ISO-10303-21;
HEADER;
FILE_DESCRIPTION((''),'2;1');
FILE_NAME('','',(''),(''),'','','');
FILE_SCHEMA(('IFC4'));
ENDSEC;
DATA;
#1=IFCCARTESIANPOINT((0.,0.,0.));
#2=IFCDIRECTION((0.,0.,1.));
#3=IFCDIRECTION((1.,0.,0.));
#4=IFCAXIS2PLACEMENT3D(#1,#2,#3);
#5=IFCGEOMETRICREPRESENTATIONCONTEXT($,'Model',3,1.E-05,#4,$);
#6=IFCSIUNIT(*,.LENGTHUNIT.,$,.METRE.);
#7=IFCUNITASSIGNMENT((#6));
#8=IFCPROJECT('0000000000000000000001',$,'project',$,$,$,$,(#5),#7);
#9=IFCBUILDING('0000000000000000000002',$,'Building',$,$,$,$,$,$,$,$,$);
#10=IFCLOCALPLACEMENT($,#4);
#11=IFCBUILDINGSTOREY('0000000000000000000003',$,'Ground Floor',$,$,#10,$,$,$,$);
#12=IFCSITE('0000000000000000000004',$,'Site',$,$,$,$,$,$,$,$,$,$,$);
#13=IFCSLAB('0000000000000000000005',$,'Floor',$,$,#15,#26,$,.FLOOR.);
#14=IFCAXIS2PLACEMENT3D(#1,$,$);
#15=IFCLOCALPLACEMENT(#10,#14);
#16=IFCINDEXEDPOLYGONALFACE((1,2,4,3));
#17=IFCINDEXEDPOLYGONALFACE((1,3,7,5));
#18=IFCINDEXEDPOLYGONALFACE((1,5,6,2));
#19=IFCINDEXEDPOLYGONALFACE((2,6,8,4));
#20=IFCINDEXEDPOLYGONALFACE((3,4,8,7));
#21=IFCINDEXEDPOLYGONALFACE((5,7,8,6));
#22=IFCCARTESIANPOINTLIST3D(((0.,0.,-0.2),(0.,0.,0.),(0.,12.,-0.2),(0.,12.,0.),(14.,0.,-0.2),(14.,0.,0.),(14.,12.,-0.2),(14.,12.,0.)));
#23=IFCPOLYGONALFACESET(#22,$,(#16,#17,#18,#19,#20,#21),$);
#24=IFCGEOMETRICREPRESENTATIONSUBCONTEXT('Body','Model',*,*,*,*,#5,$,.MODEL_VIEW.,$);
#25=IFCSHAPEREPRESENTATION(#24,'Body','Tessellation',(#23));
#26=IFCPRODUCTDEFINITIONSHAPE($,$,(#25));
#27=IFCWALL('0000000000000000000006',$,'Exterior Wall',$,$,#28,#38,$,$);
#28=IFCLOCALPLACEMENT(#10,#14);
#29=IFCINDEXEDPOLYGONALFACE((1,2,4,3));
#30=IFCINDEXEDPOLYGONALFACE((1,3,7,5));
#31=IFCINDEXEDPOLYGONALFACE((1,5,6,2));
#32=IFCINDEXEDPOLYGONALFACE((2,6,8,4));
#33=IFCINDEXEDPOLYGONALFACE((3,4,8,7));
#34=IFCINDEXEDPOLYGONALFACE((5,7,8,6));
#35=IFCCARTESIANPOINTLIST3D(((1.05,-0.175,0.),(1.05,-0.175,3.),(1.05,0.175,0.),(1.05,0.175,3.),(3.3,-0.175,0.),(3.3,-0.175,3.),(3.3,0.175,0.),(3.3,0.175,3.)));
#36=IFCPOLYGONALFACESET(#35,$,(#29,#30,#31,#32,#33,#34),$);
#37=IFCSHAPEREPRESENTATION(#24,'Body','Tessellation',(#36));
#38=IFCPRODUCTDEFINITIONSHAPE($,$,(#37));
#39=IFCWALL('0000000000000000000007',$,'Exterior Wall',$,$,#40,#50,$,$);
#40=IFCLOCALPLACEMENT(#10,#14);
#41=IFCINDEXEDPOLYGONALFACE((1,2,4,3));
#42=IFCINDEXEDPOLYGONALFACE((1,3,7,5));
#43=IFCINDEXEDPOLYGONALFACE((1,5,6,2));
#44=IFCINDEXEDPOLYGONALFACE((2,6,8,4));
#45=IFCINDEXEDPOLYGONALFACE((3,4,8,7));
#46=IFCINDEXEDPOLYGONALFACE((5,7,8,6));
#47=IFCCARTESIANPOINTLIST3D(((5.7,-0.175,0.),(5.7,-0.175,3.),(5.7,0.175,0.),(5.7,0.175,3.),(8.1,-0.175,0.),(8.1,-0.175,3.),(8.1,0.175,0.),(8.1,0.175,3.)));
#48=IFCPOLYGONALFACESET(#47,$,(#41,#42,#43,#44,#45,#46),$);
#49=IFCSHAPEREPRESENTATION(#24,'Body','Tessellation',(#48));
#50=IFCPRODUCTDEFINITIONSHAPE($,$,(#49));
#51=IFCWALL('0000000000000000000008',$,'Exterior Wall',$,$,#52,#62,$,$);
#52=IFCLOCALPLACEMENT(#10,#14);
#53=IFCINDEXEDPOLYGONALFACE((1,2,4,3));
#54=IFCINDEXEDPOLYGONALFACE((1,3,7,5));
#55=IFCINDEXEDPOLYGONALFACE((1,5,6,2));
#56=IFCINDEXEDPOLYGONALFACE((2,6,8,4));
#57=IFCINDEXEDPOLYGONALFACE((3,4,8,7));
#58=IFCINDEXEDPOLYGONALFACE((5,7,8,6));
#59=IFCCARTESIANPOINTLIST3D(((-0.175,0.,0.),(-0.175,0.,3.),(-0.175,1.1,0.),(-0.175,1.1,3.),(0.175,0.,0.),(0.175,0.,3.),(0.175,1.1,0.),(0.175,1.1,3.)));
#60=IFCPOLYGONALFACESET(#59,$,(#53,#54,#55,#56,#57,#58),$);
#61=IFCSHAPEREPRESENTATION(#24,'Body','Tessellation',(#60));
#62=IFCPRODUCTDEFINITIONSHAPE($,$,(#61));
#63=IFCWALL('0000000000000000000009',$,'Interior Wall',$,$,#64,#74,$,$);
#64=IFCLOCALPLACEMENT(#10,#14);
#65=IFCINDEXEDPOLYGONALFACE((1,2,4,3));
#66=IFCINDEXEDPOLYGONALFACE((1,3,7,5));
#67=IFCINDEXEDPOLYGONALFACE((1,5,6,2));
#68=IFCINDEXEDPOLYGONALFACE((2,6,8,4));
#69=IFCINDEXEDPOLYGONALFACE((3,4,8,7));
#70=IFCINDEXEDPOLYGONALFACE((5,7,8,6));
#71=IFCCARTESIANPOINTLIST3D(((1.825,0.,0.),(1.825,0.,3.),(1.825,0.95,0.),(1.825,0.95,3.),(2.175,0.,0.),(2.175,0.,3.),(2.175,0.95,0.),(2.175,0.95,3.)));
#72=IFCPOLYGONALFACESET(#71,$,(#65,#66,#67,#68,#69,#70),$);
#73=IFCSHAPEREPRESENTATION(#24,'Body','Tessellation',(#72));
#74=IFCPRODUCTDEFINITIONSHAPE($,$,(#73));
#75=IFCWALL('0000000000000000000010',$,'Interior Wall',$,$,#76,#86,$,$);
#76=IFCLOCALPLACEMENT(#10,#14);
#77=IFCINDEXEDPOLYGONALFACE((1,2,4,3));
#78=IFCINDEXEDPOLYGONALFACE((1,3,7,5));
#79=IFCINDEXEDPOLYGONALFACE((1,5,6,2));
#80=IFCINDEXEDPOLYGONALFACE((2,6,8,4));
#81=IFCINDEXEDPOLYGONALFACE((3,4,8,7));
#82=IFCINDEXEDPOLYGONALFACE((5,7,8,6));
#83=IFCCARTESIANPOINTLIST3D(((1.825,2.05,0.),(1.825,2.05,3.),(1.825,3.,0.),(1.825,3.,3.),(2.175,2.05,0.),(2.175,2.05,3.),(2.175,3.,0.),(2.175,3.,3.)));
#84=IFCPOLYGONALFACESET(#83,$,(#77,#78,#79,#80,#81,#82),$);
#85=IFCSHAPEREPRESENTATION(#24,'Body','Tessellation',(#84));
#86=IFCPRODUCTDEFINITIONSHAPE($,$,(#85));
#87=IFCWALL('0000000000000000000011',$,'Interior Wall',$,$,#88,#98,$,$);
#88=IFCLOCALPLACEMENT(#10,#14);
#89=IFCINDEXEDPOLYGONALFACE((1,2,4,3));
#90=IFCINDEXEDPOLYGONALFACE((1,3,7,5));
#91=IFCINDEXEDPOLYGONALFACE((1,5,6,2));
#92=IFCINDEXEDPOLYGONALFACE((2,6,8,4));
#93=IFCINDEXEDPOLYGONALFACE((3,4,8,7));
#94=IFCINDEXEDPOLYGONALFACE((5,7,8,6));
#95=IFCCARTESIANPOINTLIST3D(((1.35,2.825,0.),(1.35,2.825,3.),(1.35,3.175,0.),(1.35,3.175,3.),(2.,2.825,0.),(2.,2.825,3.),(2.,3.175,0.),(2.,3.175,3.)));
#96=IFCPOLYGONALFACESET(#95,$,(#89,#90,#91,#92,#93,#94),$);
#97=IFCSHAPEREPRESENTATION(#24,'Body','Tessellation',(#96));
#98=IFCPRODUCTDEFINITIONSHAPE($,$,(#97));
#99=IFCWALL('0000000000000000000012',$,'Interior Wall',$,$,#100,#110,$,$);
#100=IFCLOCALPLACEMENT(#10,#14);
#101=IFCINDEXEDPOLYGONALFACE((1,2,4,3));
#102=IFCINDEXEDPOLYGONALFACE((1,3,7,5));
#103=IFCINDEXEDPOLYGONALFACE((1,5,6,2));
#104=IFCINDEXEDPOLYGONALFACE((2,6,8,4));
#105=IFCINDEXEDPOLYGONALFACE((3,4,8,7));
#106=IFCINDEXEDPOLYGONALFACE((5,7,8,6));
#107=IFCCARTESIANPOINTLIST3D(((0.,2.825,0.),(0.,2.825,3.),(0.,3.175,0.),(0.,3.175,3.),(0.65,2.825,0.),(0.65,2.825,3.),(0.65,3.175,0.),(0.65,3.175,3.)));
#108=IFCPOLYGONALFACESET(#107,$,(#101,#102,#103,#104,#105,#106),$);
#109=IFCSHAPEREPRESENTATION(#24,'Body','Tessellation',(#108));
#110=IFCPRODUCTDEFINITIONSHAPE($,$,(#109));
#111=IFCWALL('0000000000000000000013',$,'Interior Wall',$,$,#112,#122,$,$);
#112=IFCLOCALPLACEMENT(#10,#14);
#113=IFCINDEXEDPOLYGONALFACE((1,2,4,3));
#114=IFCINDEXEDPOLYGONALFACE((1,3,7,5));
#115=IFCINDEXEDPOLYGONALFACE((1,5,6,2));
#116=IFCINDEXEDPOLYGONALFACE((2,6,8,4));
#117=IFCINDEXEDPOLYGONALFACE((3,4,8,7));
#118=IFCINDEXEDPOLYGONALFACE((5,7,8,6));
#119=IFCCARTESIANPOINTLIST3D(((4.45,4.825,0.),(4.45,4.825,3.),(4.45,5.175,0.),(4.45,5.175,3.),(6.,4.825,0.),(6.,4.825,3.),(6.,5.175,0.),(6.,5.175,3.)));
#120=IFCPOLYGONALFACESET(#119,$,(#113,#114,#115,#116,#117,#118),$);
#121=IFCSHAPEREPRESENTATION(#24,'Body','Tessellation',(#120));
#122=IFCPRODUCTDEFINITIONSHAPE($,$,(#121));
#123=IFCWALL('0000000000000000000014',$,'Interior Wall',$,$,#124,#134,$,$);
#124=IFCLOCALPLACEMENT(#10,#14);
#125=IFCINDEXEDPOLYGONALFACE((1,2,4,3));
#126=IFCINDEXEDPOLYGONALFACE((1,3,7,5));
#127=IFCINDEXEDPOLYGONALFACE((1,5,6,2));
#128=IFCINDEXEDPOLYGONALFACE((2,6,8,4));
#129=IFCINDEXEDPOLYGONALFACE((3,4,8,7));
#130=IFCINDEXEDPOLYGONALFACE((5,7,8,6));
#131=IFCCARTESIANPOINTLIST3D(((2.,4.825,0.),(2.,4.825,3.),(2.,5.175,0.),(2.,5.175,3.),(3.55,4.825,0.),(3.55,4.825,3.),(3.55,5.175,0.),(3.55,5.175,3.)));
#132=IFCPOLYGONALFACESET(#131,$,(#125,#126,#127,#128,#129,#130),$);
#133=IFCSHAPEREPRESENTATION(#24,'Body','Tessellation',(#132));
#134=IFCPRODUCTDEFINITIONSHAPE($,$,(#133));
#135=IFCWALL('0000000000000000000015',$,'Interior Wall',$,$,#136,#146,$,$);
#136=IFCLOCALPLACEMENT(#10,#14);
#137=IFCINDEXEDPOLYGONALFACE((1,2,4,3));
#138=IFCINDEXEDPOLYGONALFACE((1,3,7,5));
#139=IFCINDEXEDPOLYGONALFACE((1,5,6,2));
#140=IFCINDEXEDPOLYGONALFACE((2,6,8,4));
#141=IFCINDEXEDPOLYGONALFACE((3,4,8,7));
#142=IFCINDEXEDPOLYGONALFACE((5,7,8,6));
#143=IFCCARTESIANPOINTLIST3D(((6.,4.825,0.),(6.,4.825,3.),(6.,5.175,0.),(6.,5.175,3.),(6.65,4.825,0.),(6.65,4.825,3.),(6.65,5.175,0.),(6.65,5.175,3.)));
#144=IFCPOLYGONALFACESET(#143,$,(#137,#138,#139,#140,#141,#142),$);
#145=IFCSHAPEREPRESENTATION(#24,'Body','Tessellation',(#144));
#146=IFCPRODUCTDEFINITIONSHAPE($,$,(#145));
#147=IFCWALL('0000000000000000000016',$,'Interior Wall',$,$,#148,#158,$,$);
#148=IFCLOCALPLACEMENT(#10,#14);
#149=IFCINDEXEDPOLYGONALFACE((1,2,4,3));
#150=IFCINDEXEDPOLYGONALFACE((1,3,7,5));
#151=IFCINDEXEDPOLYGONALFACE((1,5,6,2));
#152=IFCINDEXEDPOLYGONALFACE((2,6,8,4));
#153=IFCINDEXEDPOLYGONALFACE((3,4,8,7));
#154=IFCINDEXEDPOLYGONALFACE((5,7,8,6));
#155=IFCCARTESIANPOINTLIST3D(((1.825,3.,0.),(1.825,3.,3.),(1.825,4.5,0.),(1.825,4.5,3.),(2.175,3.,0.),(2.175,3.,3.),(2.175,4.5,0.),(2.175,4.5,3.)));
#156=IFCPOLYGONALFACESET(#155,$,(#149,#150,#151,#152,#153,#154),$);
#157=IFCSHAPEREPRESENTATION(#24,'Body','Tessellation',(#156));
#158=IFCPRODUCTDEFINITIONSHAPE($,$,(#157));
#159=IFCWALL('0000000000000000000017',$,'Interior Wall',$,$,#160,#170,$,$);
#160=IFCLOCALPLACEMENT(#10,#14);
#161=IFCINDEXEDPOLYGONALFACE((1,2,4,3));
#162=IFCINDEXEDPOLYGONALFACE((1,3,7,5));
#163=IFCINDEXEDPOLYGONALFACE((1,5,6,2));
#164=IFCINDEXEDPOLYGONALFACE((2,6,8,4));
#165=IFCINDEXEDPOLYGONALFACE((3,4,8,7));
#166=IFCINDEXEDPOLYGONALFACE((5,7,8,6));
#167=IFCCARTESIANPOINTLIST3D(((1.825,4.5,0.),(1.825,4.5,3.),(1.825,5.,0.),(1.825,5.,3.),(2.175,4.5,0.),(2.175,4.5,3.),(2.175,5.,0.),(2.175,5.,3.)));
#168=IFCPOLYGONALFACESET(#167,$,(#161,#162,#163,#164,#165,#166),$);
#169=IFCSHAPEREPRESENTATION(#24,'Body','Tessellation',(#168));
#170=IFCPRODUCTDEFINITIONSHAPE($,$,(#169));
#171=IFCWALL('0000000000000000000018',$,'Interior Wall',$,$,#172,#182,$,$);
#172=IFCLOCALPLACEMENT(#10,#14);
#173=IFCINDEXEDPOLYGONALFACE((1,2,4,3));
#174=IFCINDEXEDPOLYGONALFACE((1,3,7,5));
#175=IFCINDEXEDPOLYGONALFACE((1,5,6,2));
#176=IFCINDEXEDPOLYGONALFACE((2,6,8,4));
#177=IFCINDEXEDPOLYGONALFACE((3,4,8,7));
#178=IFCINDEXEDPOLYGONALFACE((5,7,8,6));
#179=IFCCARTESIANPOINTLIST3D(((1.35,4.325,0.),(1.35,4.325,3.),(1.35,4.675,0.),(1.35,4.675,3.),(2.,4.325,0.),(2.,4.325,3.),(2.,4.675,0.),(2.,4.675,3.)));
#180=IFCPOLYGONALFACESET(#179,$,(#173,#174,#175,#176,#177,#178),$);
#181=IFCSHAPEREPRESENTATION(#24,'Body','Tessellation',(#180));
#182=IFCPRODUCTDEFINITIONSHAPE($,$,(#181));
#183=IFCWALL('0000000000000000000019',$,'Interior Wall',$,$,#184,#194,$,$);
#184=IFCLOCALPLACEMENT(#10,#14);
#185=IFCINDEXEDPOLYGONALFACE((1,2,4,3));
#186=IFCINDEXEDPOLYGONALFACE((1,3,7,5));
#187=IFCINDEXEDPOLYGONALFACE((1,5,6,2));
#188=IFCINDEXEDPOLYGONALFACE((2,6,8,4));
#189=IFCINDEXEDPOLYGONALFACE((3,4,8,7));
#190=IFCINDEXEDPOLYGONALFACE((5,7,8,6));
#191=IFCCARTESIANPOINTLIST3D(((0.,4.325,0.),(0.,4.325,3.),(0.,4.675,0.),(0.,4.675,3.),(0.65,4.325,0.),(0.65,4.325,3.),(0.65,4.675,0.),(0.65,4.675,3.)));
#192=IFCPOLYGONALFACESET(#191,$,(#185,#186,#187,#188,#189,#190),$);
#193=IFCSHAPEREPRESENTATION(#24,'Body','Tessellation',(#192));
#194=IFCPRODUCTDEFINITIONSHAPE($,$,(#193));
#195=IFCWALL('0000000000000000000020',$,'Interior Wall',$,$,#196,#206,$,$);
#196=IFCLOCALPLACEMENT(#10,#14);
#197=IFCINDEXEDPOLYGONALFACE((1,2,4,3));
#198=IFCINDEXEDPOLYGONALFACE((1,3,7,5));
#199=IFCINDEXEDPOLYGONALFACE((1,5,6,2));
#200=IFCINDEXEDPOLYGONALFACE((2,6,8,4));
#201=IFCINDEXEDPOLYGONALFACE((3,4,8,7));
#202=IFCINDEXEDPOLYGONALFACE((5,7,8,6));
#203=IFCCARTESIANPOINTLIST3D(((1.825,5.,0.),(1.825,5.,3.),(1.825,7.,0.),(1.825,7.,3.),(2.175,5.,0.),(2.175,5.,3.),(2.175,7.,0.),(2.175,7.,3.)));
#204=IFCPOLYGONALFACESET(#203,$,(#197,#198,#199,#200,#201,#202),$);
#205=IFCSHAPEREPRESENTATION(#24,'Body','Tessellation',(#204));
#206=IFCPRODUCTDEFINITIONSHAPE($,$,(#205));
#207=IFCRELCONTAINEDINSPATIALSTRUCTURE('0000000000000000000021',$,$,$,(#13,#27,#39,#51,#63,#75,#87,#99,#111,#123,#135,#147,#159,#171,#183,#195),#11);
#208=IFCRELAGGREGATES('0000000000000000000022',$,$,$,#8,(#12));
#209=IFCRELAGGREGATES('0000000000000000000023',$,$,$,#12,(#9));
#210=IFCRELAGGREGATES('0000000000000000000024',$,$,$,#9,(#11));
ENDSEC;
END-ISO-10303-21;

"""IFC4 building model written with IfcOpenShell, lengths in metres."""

from ifc_helpers import new_model, si_unit, frame, origin_with_axes, place, context, subcontext, project, spatial, indexed_curve, outline, extrude, element, save


model = new_model("IFC4")

# Units and contexts
model_context = context("Model", 3, precision=1e-05, world=origin_with_axes())
body_context = subcontext(model_context, "Body", "Model", "MODEL_VIEW")
ifc_project = project(units=[si_unit("LENGTHUNIT", "METRE")], contexts=[model_context])

# Site, building, storey
site = spatial("IfcSite", under=ifc_project, Name="Site")
building = spatial("IfcBuilding", under=site, Name="Building")
storey_placement = place(None, origin_with_axes())
storey = spatial("IfcBuildingStorey", under=building, at=storey_placement, Name="Ground Floor")

# Slab
slab_placement = place(storey_placement, frame((0.0, 0.0, -0.2), z_axis=(0.0, 0.0, 1.0), x_axis=(1.0, 0.0, 0.0)))
element("IfcSlab", 1, at=slab_placement, inside=storey, Name="Floor", PredefinedType="FLOOR", context=body_context, shape_type="SweptSolid", body=[
    extrude(outline(indexed_curve([(0.0, 0.0), (14.0, 0.0), (14.0, 12.0), (0.0, 12.0)])), None, (0.0, 0.0, 1.0), 0.2),
])

# Walls
wall_1_placement = place(storey_placement, frame((1.05, 0.0, 0.0), z_axis=(0.0, 0.0, 1.0), x_axis=(1.0, 0.0, 0.0)))
element("IfcWall", 2, at=wall_1_placement, inside=storey, Name="Exterior Wall", context=body_context, shape_type="SweptSolid", body=[
    extrude(outline(indexed_curve([(0.0, 0.0), (0.0, 0.35), (2.25, 0.35), (2.25, 0.0), (0.0, 0.0)], self_intersect=False)), frame((0.0, -0.175, 0.0), z_axis=(0.0, 0.0, 1.0), x_axis=(1.0, 0.0, 0.0)), (0.0, 0.0, 1.0), 3.0),
])
wall_2_placement = place(storey_placement, frame((5.7, 0.0, 0.0), z_axis=(0.0, 0.0, 1.0), x_axis=(1.0, 0.0, 0.0)))
element("IfcWall", 3, at=wall_2_placement, inside=storey, Name="Exterior Wall", context=body_context, shape_type="SweptSolid", body=[
    extrude(outline(indexed_curve([(0.0, 0.0), (0.0, 0.35), (2.4, 0.35), (2.4, 0.0), (0.0, 0.0)], self_intersect=False)), frame((0.0, -0.175, 0.0), z_axis=(0.0, 0.0, 1.0), x_axis=(1.0, 0.0, 0.0)), (0.0, 0.0, 1.0), 3.0),
])
wall_3_placement = place(storey_placement, frame((0.0, 1.1, 0.0), z_axis=(0.0, 0.0, 1.0), x_axis=(0.0, -1.0, 0.0)))
element("IfcWall", 4, at=wall_3_placement, inside=storey, Name="Exterior Wall", context=body_context, shape_type="SweptSolid", body=[
    extrude(outline(indexed_curve([(0.0, 0.0), (0.0, 0.35), (1.1, 0.35), (1.1, 0.0), (0.0, 0.0)], self_intersect=False)), frame((0.0, -0.175, 0.0), z_axis=(0.0, 0.0, 1.0), x_axis=(1.0, 0.0, 0.0)), (0.0, 0.0, 1.0), 3.0),
])
wall_4_placement = place(storey_placement, frame((2.0, 0.0, 0.0), z_axis=(0.0, 0.0, 1.0), x_axis=(0.0, 1.0, 0.0)))
element("IfcWall", 5, at=wall_4_placement, inside=storey, Name="Interior Wall", context=body_context, shape_type="SweptSolid", body=[
    extrude(outline(indexed_curve([(0.0, 0.0), (0.0, 0.35), (0.95, 0.35), (0.95, 0.0), (0.0, 0.0)], self_intersect=False)), frame((0.0, -0.175, 0.0), z_axis=(0.0, 0.0, 1.0), x_axis=(1.0, 0.0, 0.0)), (0.0, 0.0, 1.0), 3.0),
])
wall_5_placement = place(storey_placement, frame((2.0, 2.05, 0.0), z_axis=(0.0, 0.0, 1.0), x_axis=(0.0, 1.0, 0.0)))
element("IfcWall", 6, at=wall_5_placement, inside=storey, Name="Interior Wall", context=body_context, shape_type="SweptSolid", body=[
    extrude(outline(indexed_curve([(0.0, 0.0), (0.0, 0.35), (0.95, 0.35), (0.95, 0.0), (0.0, 0.0)], self_intersect=False)), frame((0.0, -0.175, 0.0), z_axis=(0.0, 0.0, 1.0), x_axis=(1.0, 0.0, 0.0)), (0.0, 0.0, 1.0), 3.0),
])
for number, where, z_axis, x_axis, name in (
    (7, (2.0, 3.0, 0.0), (0.0, 0.0, 1.0), (-1.0, 0.0, 0.0), "Interior Wall"),
    (8, (0.65, 3.0, 0.0), (0.0, 0.0, 1.0), (-1.0, 0.0, 0.0), "Interior Wall"),
):
    element("IfcWall", number, at=place(storey_placement, frame(where, z_axis=z_axis, x_axis=x_axis)), inside=storey, Name=name, context=body_context, shape_type="SweptSolid", body=[
        extrude(outline(indexed_curve([(0.0, 0.0), (0.0, 0.35), (0.65, 0.35), (0.65, 0.0), (0.0, 0.0)], self_intersect=False)), frame((0.0, -0.175, 0.0), z_axis=(0.0, 0.0, 1.0), x_axis=(1.0, 0.0, 0.0)), (0.0, 0.0, 1.0), 3.0),
    ])
for number, where, z_axis, x_axis, name in (
    (9, (6.0, 5.0, 0.0), (0.0, 0.0, 1.0), (-1.0, 0.0, 0.0), "Interior Wall"),
    (10, (3.55, 5.0, 0.0), (0.0, 0.0, 1.0), (-1.0, 0.0, 0.0), "Interior Wall"),
):
    element("IfcWall", number, at=place(storey_placement, frame(where, z_axis=z_axis, x_axis=x_axis)), inside=storey, Name=name, context=body_context, shape_type="SweptSolid", body=[
        extrude(outline(indexed_curve([(0.0, 0.0), (0.0, 0.35), (1.55, 0.35), (1.55, 0.0), (0.0, 0.0)], self_intersect=False)), frame((0.0, -0.175, 0.0), z_axis=(0.0, 0.0, 1.0), x_axis=(1.0, 0.0, 0.0)), (0.0, 0.0, 1.0), 3.0),
    ])
wall_6_placement = place(storey_placement, frame((6.65, 5.0, 0.0), z_axis=(0.0, 0.0, 1.0), x_axis=(-1.0, 0.0, 0.0)))
element("IfcWall", 11, at=wall_6_placement, inside=storey, Name="Interior Wall", context=body_context, shape_type="SweptSolid", body=[
    extrude(outline(indexed_curve([(0.0, 0.0), (0.0, 0.35), (0.65, 0.35), (0.65, 0.0), (0.0, 0.0)], self_intersect=False)), frame((0.0, -0.175, 0.0), z_axis=(0.0, 0.0, 1.0), x_axis=(1.0, 0.0, 0.0)), (0.0, 0.0, 1.0), 3.0),
])
wall_7_placement = place(storey_placement, frame((2.0, 4.5, 0.0), z_axis=(0.0, 0.0, 1.0), x_axis=(0.0, -1.0, 0.0)))
element("IfcWall", 12, at=wall_7_placement, inside=storey, Name="Interior Wall", context=body_context, shape_type="SweptSolid", body=[
    extrude(outline(indexed_curve([(0.0, 0.0), (0.0, 0.35), (1.5, 0.35), (1.5, 0.0), (0.0, 0.0)], self_intersect=False)), frame((0.0, -0.175, 0.0), z_axis=(0.0, 0.0, 1.0), x_axis=(1.0, 0.0, 0.0)), (0.0, 0.0, 1.0), 3.0),
])
wall_8_placement = place(storey_placement, frame((2.0, 5.0, 0.0), z_axis=(0.0, 0.0, 1.0), x_axis=(0.0, -1.0, 0.0)))
element("IfcWall", 13, at=wall_8_placement, inside=storey, Name="Interior Wall", context=body_context, shape_type="SweptSolid", body=[
    extrude(outline(indexed_curve([(0.0, 0.0), (0.0, 0.35), (0.5, 0.35), (0.5, 0.0), (0.0, 0.0)], self_intersect=False)), frame((0.0, -0.175, 0.0), z_axis=(0.0, 0.0, 1.0), x_axis=(1.0, 0.0, 0.0)), (0.0, 0.0, 1.0), 3.0),
])
for number, where, z_axis, x_axis, name in (
    (14, (2.0, 4.5, 0.0), (0.0, 0.0, 1.0), (-1.0, 0.0, 0.0), "Interior Wall"),
    (15, (0.65, 4.5, 0.0), (0.0, 0.0, 1.0), (-1.0, 0.0, 0.0), "Interior Wall"),
):
    element("IfcWall", number, at=place(storey_placement, frame(where, z_axis=z_axis, x_axis=x_axis)), inside=storey, Name=name, context=body_context, shape_type="SweptSolid", body=[
        extrude(outline(indexed_curve([(0.0, 0.0), (0.0, 0.35), (0.65, 0.35), (0.65, 0.0), (0.0, 0.0)], self_intersect=False)), frame((0.0, -0.175, 0.0), z_axis=(0.0, 0.0, 1.0), x_axis=(1.0, 0.0, 0.0)), (0.0, 0.0, 1.0), 3.0),
    ])
wall_9_placement = place(storey_placement, frame((2.0, 5.0, 0.0), z_axis=(0.0, 0.0, 1.0), x_axis=(0.0, 1.0, 0.0)))
element("IfcWall", 16, at=wall_9_placement, inside=storey, Name="Interior Wall", context=body_context, shape_type="SweptSolid", body=[
    extrude(outline(indexed_curve([(0.0, 0.0), (0.0, 0.35), (2.0, 0.35), (2.0, 0.0), (0.0, 0.0)], self_intersect=False)), frame((0.0, -0.175, 0.0), z_axis=(0.0, 0.0, 1.0), x_axis=(1.0, 0.0, 0.0)), (0.0, 0.0, 1.0), 3.0),
])

save(model, "model.ifc")
